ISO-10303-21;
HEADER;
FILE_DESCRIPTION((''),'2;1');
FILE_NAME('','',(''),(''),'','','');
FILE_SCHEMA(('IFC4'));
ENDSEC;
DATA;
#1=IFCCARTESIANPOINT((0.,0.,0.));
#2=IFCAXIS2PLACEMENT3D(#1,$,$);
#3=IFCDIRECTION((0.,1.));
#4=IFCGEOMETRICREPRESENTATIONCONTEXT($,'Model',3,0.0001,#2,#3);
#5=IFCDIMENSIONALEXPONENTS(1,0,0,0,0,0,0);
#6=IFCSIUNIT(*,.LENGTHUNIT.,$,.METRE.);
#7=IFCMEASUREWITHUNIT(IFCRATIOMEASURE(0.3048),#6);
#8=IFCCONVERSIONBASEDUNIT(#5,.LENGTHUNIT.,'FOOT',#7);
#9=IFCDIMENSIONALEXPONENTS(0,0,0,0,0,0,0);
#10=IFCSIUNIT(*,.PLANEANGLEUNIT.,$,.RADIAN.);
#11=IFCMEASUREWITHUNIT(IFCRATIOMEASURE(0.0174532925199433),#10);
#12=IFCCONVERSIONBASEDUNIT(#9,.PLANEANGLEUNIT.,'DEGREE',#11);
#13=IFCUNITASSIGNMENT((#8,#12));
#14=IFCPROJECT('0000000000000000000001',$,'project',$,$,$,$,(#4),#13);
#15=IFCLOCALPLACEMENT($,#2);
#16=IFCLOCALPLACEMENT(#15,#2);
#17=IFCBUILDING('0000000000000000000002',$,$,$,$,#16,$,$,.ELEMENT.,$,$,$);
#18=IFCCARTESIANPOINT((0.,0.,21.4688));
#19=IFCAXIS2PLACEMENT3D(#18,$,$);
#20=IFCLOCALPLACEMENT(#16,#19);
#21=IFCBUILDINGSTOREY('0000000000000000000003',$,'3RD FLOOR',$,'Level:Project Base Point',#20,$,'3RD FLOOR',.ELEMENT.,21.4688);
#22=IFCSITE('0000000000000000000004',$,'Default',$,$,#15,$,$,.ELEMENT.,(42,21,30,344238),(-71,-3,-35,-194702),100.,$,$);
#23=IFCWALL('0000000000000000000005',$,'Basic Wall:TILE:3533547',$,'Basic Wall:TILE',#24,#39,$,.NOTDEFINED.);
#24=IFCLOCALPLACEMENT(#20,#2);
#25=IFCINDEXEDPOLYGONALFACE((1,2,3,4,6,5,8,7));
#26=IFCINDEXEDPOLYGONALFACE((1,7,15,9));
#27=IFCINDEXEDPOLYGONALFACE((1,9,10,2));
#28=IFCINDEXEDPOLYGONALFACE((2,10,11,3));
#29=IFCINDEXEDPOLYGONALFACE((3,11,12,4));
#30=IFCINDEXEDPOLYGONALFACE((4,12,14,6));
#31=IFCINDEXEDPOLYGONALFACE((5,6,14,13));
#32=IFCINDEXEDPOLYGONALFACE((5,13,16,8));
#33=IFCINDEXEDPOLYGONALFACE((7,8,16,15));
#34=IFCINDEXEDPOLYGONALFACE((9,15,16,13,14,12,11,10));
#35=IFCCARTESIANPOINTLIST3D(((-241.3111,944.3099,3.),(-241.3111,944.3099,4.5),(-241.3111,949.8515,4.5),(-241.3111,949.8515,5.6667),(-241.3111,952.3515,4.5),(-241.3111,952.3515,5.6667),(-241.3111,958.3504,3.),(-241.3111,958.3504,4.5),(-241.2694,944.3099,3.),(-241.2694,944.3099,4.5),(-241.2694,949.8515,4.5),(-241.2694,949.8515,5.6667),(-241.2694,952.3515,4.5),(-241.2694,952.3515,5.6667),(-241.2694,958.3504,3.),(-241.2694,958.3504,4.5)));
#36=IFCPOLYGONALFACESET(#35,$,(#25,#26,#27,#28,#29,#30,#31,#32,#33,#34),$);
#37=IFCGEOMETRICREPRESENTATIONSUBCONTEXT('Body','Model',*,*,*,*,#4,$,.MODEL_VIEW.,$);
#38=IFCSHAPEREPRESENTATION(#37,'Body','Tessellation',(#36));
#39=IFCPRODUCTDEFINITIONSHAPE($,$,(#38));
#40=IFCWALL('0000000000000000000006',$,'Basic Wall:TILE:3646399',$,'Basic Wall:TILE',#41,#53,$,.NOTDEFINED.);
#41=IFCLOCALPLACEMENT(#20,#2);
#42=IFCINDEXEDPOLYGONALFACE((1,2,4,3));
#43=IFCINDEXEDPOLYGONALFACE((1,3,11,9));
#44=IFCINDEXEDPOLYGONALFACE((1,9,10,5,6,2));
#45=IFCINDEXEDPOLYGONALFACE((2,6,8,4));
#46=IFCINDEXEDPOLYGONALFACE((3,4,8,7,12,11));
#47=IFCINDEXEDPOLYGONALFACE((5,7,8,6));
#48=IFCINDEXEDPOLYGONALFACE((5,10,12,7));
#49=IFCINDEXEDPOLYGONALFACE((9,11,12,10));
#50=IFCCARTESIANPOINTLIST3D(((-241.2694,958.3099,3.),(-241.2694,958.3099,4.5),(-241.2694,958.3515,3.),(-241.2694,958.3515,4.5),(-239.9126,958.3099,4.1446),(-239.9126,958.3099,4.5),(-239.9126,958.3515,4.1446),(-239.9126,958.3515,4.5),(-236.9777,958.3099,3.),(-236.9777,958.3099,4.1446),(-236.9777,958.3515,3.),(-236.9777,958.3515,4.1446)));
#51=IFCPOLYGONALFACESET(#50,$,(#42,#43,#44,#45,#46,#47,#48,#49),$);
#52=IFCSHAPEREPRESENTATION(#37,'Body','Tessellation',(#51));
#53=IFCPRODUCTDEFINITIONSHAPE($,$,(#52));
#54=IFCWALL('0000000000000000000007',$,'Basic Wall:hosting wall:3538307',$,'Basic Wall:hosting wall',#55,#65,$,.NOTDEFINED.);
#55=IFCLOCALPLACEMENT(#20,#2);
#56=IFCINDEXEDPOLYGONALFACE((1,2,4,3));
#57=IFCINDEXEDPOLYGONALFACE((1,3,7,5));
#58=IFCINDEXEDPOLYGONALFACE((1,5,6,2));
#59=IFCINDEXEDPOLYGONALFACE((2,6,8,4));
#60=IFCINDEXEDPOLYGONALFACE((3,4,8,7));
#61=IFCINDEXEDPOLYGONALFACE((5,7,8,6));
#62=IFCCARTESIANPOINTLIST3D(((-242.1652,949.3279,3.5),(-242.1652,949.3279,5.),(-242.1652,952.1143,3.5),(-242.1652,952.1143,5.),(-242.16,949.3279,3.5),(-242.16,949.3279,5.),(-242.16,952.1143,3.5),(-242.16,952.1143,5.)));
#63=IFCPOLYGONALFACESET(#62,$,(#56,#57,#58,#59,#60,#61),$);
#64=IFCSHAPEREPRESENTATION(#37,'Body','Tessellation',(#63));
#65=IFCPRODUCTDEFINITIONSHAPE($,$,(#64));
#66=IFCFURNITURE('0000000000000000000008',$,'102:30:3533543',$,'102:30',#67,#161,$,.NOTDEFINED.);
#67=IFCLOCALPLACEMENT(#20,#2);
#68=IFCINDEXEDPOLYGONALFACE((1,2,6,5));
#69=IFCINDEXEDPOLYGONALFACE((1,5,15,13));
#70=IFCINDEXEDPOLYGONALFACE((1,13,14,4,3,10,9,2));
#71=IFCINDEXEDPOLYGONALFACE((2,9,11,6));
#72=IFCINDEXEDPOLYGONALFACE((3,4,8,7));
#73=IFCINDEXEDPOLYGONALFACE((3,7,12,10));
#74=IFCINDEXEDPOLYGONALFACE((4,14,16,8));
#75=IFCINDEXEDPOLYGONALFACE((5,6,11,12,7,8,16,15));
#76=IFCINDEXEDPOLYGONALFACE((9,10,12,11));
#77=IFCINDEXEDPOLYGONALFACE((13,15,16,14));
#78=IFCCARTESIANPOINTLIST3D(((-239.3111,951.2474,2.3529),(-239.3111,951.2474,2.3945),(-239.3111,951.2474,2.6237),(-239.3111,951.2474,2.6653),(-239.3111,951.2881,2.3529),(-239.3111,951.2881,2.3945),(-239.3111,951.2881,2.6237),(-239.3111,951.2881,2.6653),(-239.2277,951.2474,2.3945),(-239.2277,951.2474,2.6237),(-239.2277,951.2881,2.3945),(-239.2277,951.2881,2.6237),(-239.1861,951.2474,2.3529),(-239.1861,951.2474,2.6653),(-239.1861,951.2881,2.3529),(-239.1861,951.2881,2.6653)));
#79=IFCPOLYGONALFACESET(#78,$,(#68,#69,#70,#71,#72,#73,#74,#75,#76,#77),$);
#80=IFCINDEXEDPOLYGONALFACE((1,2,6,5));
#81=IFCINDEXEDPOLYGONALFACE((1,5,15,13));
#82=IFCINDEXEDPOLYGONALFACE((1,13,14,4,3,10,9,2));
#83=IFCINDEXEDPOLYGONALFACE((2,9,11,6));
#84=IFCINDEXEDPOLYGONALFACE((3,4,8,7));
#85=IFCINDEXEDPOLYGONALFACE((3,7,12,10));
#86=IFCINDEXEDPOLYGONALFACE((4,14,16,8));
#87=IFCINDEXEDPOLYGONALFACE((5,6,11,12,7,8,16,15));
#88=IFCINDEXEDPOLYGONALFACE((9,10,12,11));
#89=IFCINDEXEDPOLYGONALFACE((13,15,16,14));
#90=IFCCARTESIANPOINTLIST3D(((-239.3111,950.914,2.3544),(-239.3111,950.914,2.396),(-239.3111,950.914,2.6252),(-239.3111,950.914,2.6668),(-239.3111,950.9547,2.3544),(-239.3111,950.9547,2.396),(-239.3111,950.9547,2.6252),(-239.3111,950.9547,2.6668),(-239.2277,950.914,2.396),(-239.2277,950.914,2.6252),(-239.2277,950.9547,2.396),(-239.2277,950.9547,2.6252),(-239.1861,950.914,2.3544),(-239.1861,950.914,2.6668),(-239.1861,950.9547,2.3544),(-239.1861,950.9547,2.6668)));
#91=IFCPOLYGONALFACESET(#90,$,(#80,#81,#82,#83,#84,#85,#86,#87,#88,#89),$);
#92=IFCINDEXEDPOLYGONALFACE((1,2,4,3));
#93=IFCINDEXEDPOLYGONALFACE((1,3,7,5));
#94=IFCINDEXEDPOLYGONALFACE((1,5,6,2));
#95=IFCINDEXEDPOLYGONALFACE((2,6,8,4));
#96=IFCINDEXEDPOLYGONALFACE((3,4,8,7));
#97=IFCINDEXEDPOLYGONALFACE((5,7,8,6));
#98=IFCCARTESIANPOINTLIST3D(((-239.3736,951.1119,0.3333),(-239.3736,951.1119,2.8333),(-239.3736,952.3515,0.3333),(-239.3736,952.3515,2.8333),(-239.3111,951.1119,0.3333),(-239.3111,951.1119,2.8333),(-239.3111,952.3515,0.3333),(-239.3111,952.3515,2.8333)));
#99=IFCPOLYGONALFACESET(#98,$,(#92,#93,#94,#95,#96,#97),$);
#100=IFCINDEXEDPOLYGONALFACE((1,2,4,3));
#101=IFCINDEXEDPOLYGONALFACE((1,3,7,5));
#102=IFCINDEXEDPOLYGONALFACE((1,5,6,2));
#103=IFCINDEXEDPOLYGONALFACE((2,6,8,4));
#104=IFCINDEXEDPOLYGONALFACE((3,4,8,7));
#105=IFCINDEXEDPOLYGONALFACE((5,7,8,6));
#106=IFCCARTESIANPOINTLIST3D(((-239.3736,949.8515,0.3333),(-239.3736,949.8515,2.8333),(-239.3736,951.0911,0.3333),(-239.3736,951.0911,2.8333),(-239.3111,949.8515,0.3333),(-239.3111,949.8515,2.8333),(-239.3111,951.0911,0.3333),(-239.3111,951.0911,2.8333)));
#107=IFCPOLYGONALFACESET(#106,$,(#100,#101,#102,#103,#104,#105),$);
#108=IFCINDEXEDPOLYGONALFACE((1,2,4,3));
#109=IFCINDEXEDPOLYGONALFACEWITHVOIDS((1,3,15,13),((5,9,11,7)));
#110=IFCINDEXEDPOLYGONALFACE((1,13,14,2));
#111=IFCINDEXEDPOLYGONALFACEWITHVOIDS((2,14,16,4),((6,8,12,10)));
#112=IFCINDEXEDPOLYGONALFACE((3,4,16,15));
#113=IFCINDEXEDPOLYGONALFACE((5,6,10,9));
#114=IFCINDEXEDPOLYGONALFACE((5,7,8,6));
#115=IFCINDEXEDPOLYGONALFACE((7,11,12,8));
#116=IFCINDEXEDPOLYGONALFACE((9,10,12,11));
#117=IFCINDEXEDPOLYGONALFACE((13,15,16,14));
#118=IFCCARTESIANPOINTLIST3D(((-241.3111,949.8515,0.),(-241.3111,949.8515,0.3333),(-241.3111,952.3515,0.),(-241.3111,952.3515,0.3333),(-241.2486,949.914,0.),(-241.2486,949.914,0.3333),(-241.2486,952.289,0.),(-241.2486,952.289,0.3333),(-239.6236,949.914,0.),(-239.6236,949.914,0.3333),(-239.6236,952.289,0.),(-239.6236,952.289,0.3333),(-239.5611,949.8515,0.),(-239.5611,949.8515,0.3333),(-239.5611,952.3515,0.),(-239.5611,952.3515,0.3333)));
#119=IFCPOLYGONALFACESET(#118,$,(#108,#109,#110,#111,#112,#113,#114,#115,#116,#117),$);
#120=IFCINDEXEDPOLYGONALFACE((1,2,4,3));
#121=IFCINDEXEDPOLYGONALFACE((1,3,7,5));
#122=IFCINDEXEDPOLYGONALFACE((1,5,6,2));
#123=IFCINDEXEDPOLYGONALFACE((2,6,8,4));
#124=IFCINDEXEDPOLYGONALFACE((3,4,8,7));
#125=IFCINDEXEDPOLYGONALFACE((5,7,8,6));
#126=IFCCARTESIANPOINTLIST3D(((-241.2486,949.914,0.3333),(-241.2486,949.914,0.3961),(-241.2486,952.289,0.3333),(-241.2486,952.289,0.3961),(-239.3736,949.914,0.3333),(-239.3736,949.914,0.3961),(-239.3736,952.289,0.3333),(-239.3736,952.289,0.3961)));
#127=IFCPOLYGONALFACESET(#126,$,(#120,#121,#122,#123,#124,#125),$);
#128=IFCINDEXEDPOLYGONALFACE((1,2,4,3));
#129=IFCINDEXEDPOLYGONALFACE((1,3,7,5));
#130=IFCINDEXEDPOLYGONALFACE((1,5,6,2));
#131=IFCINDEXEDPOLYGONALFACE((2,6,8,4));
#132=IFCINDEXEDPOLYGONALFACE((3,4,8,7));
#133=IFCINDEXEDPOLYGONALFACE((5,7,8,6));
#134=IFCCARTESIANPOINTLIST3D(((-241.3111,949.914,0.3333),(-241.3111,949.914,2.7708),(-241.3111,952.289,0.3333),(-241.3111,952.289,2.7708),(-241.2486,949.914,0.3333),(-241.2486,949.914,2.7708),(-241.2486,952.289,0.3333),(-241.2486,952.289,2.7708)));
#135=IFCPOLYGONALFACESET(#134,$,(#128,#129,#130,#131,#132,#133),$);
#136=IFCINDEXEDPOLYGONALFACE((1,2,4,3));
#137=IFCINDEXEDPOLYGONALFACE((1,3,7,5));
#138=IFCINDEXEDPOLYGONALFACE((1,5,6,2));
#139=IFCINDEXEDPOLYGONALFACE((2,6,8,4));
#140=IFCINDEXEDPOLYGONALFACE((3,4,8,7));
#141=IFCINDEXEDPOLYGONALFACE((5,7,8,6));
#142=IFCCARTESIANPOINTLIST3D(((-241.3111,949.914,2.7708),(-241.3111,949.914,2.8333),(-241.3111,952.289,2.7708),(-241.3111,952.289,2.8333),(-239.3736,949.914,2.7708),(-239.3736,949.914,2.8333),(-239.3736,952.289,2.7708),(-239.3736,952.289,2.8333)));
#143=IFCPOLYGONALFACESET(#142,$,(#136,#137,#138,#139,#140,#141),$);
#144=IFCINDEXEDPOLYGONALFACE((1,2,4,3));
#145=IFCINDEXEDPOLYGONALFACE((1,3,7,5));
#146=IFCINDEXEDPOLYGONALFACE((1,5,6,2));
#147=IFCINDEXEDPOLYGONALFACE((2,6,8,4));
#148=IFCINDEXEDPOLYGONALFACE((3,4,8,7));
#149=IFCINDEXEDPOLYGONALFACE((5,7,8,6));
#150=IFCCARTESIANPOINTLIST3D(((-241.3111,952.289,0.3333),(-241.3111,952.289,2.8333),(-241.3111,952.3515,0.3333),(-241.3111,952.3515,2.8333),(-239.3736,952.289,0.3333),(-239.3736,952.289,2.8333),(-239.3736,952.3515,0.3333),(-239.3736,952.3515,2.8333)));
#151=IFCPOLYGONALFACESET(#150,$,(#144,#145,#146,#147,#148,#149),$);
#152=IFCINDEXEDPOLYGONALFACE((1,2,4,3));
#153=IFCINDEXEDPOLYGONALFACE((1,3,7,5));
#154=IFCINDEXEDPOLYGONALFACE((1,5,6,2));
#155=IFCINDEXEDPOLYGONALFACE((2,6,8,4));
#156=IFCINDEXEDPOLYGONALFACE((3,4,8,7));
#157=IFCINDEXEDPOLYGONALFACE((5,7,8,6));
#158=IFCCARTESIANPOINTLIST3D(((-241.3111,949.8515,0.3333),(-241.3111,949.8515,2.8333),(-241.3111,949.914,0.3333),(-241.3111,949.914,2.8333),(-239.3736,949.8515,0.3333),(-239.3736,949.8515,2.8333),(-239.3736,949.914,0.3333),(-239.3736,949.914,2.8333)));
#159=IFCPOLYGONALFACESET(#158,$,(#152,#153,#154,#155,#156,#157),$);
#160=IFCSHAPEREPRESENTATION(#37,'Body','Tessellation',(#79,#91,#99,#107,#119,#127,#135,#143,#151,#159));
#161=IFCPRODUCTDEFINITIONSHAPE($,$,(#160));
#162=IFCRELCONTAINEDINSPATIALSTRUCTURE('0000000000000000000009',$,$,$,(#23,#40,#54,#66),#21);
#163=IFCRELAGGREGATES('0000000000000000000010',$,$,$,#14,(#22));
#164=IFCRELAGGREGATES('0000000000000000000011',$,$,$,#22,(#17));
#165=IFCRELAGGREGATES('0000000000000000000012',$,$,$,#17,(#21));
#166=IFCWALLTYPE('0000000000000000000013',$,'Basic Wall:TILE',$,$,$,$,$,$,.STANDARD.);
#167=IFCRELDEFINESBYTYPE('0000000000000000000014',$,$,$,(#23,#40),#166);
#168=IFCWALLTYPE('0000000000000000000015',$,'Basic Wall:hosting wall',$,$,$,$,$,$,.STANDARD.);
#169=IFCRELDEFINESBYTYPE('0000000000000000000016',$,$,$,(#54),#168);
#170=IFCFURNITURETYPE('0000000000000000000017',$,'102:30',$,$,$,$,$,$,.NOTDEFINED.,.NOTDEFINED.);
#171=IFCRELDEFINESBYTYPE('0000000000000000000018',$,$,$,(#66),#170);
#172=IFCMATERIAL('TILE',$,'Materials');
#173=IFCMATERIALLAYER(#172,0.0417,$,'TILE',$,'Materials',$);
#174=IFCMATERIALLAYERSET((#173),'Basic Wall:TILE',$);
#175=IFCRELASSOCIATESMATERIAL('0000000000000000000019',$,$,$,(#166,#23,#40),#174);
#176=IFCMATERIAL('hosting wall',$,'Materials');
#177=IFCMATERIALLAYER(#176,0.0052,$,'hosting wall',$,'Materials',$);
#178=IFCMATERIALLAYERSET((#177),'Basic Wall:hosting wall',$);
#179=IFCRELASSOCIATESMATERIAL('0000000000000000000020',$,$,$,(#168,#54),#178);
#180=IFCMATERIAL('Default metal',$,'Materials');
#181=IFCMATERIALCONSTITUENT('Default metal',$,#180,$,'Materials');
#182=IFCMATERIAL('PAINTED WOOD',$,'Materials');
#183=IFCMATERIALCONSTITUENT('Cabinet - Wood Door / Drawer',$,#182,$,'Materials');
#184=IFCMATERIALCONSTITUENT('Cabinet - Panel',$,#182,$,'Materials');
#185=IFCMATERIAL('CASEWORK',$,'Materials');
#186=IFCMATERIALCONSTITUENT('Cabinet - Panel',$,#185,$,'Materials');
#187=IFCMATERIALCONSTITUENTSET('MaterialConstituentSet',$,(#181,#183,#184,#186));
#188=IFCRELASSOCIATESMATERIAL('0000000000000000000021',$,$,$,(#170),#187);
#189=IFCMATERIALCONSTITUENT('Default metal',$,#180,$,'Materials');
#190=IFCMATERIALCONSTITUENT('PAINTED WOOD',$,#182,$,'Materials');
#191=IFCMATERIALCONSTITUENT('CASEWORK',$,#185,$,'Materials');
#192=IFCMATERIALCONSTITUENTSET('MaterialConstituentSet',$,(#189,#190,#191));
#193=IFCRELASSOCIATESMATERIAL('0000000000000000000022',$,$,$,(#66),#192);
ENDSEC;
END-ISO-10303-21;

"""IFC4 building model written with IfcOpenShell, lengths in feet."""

from ifc_helpers import new_model, entity, si_unit, converted_unit, direction, frame, frame_2d, origin, origin_2d_with_axis, place, context, subcontext, project, spatial, polyline, rectangle, outline, extrude, source, transform, mapped, material, layer, layer_set, layer_usage, constituent, constituent_set, type_object, type_shapes, element, save


model = new_model("IFC4")

# Units and contexts
model_context = context("Model", 3, precision=0.0001, world=origin(), true_north=direction((0.0, 1.0)))
body_context = subcontext(model_context, "Body", "Model", "MODEL_VIEW")
ifc_project = project(units=[converted_unit("LENGTHUNIT", "FOOT", entity("IfcRatioMeasure", 0.3048), si_unit("LENGTHUNIT", "METRE"), dimensions=[1, 0, 0, 0, 0, 0, 0]), converted_unit("PLANEANGLEUNIT", "DEGREE", entity("IfcRatioMeasure", 0.0174532925199433), si_unit("PLANEANGLEUNIT", "RADIAN"), dimensions=[0, 0, 0, 0, 0, 0, 0])], contexts=[model_context])

# Site, building, storey
site_placement = place(None, origin())
site = spatial("IfcSite", under=ifc_project, at=site_placement, Name="Default", CompositionType="ELEMENT", RefLatitude=(42, 21, 30, 344238), RefLongitude=(-71, -3, -35, -194702), RefElevation=100.0)
building_placement = place(site_placement, origin())
building = spatial("IfcBuilding", under=site, at=building_placement, CompositionType="ELEMENT")
storey_placement = place(building_placement, frame((0.0, 0.0, 21.4688)))
storey = spatial("IfcBuildingStorey", under=building, at=storey_placement, Name="3RD FLOOR", ObjectType="Level:Project Base Point", LongName="3RD FLOOR", CompositionType="ELEMENT", Elevation=21.4688)

# Wall, openings
ifc_material_1 = material(Name="TILE", Category="Materials")
ifc_layer_1 = layer(ifc_material_1, 0.0417, Name="TILE", Category="Materials")
ifc_layer_set_1 = layer_set([ifc_layer_1], Name="Basic Wall:TILE")
ifc_layer_usage_1 = layer_usage(ifc_layer_set_1, "AXIS2", "POSITIVE", -0.0208)
wall_type_1 = type_object("IfcWallType", Name="Basic Wall:TILE", PredefinedType="STANDARD", material=ifc_layer_set_1)
wall_1_placement = place(storey_placement, frame((-241.2902, 958.3504, 3.0), z_axis=(0.0, 0.0, 1.0), x_axis=(0.0, -1.0, 0.0)))
wall_1 = element("IfcWall", 1, at=wall_1_placement, inside=storey, type_object=wall_type_1, material=ifc_layer_usage_1, Name="Basic Wall:TILE:3533547", ObjectType="Basic Wall:TILE", PredefinedType="NOTDEFINED", context=body_context, shape_type="SweptSolid", body=[
    extrude(rectangle(XDim=14.0406, YDim=0.0417, at=frame_2d((7.0203, 0.0), x_axis=(-1.0, 0.0))), origin(), (0.0, 0.0, 1.0), 2.6667),
])
opening_1_placement = place(wall_1_placement, origin())
element("IfcOpeningElement", 2, at=opening_1_placement, cuts=wall_1, PredefinedType="OPENING", context=body_context, shape_type="SweptSolid", body=[
    extrude(rectangle(XDim=1.1667, YDim=5.5417, at=origin_2d_with_axis()), frame((11.2697, 0.0208, 2.0833), z_axis=(0.0, -1.0, 0.0), x_axis=(0.0, 0.0, 1.0)), (0.0, 0.0, 1.0), 0.0417),
])
opening_2_placement = place(wall_1_placement, origin())
element("IfcOpeningElement", 3, at=opening_2_placement, cuts=wall_1, PredefinedType="OPENING", context=body_context, shape_type="SweptSolid", body=[
    extrude(rectangle(XDim=1.1667, YDim=5.9989, at=frame_2d((0.0, 0.0), x_axis=(0.0, 1.0))), frame((2.9994, 0.0208, 2.0833), z_axis=(0.0, -1.0, 0.0), x_axis=(-1.0, 0.0, 0.0)), (0.0, 0.0, 1.0), 0.0417),
])

# Wall, opening
ifc_layer_usage_2 = layer_usage(ifc_layer_set_1, "AXIS2", "NEGATIVE", 0.0208)
wall_2_placement = place(storey_placement, frame((-241.2694, 958.3307, 3.0)))
wall_2 = element("IfcWall", 4, at=wall_2_placement, inside=storey, type_object=wall_type_1, material=ifc_layer_usage_2, Name="Basic Wall:TILE:3646399", ObjectType="Basic Wall:TILE", PredefinedType="NOTDEFINED", context=body_context, shape_type="SweptSolid", body=[
    extrude(rectangle(XDim=4.2917, YDim=0.0417, at=frame_2d((2.1458, 0.0), x_axis=(-1.0, 0.0))), origin(), (0.0, 0.0, 1.0), 1.5),
])
opening_3_placement = place(wall_2_placement, origin())
element("IfcOpeningElement", 5, at=opening_3_placement, cuts=wall_2, PredefinedType="OPENING", context=body_context, shape_type="SweptSolid", body=[
    extrude(rectangle(XDim=0.3554, YDim=2.9349, at=frame_2d((0.0, 0.0), x_axis=(1.0, 0.0))), frame((2.8242, 0.0208, 1.3223), z_axis=(0.0, -1.0, 0.0), x_axis=(0.0, 0.0, 1.0)), (0.0, 0.0, 1.0), 0.0417),
])

# Wall
ifc_material_2 = material(Name="hosting wall", Category="Materials")
ifc_layer_2 = layer(ifc_material_2, 0.0052, Name="hosting wall", Category="Materials")
ifc_layer_set_2 = layer_set([ifc_layer_2], Name="Basic Wall:hosting wall")
ifc_layer_usage_3 = layer_usage(ifc_layer_set_2, "AXIS2", "POSITIVE", -0.0026)
wall_type_2 = type_object("IfcWallType", Name="Basic Wall:hosting wall", PredefinedType="STANDARD", material=ifc_layer_set_2)
wall_3_placement = place(storey_placement, frame((-242.1626, 949.3279, 3.5), z_axis=(0.0, 0.0, 1.0), x_axis=(0.0, 1.0, 0.0)))
element("IfcWall", 6, at=wall_3_placement, inside=storey, type_object=wall_type_2, material=ifc_layer_usage_3, Name="Basic Wall:hosting wall:3538307", ObjectType="Basic Wall:hosting wall", PredefinedType="NOTDEFINED", context=body_context, shape_type="SweptSolid", body=[
    extrude(rectangle(XDim=2.7865, YDim=0.0052, at=frame_2d((1.3932, 0.0), x_axis=(-1.0, 0.0))), origin(), (0.0, 0.0, 1.0), 1.5),
])

# Furniture
ifc_material_3 = material(Name="Default metal", Category="Materials")
ifc_material_4 = material(Name="PAINTED WOOD", Category="Materials")
ifc_material_5 = material(Name="CASEWORK", Category="Materials")
ifc_constituent_1 = constituent(ifc_material_3, Name="Default metal", Category="Materials")
ifc_constituent_2 = constituent(ifc_material_4, Name="PAINTED WOOD", Category="Materials")
ifc_constituent_3 = constituent(ifc_material_5, Name="CASEWORK", Category="Materials")
ifc_constituent_set_1 = constituent_set(constituents=[ifc_constituent_1, ifc_constituent_2, ifc_constituent_3], Name="MaterialConstituentSet")
ifc_constituent_4 = constituent(ifc_material_3, Name="Default metal", Category="Materials")
ifc_constituent_5 = constituent(ifc_material_4, Name="Cabinet - Wood Door / Drawer", Category="Materials")
ifc_constituent_6 = constituent(ifc_material_4, Name="Cabinet - Panel", Category="Materials")
ifc_constituent_7 = constituent(ifc_material_5, Name="Cabinet - Panel", Category="Materials")
ifc_constituent_set_2 = constituent_set(constituents=[ifc_constituent_4, ifc_constituent_5, ifc_constituent_6, ifc_constituent_7], Name="MaterialConstituentSet")
furniture_type_1 = type_object("IfcFurnitureType", Name="102:30", AssemblyPlace="NOTDEFINED", PredefinedType="NOTDEFINED", material=ifc_constituent_set_2)
shared_shape_1 = source(origin(), body_context, "Body", "SweptSolid", [
    extrude(outline(polyline([(0.1146, -0.0521), (0.1562, -0.0521), (0.1562, 0.0729), (-0.1562, 0.0729), (-0.1562, -0.0521), (-0.1146, -0.0521), (-0.1146, 0.0313), (0.1146, 0.0313), (0.1146, -0.0521)])), frame((0.2073, -2.0521, 2.5091), z_axis=(1.0, 0.0, 0.0), x_axis=(0.0, 0.0, 1.0)), (0.0, 0.0, 1.0), 0.0407),
    extrude(outline(polyline([(0.1146, -0.0521), (0.1562, -0.0521), (0.1562, 0.0729), (-0.1562, 0.0729), (-0.1562, -0.0521), (-0.1146, -0.0521), (-0.1146, 0.0313), (0.1146, 0.0313), (0.1146, -0.0521)])), frame((-0.126, -2.0521, 2.5106), z_axis=(1.0, 0.0, 0.0), x_axis=(0.0, 0.0, 1.0)), (0.0, 0.0, 1.0), 0.0407),
    extrude(rectangle(XDim=0.0625, YDim=1.2396, at=frame_2d((0.0, 0.0), x_axis=(1.0, 0.0))), frame((0.6917, -1.9688, 0.3333), z_axis=(0.0, 0.0, 1.0), x_axis=(0.0, 1.0, 0.0)), (0.0, 0.0, 1.0), 2.5),
    extrude(rectangle(XDim=0.0625, YDim=1.2396, at=origin_2d_with_axis()), frame((-0.5687, -1.9688, 0.3333), z_axis=(0.0, 0.0, 1.0), x_axis=(0.0, 1.0, 0.0)), (0.0, 0.0, 1.0), 2.5),
    extrude(outline(polyline([(-1.25, -0.875), (1.25, -0.875), (1.25, 0.875), (-1.25, 0.875), (-1.25, -0.875)]), holes=[polyline([(-1.1875, -0.8125), (-1.1875, 0.8125), (1.1875, 0.8125), (1.1875, -0.8125), (-1.1875, -0.8125)])]), frame((0.0615, -0.875, 0.0)), (0.0, 0.0, 1.0), 0.3333),
    extrude(rectangle(XDim=2.375, YDim=1.875, at=frame_2d((0.0, 0.0), x_axis=(1.0, 0.0))), frame((0.0615, -1.0, 0.3333), z_axis=(0.0, 0.0, 1.0), x_axis=(-1.0, 0.0, 0.0)), (0.0, 0.0, 1.0), 0.0627),
    extrude(rectangle(XDim=0.0625, YDim=2.375, at=origin_2d_with_axis()), frame((0.0615, -0.0312, 0.3333), z_axis=(0.0, 0.0, 1.0), x_axis=(0.0, 1.0, 0.0)), (0.0, 0.0, 1.0), 2.4375),
    extrude(rectangle(XDim=2.375, YDim=1.9375, at=origin_2d_with_axis()), frame((0.0615, -0.9688, 2.7708), z_axis=(0.0, 0.0, 1.0), x_axis=(-1.0, 0.0, 0.0)), (0.0, 0.0, 1.0), 0.0625),
    extrude(rectangle(XDim=0.0625, YDim=1.9375, at=frame_2d((0.0, 0.0), x_axis=(1.0, 0.0))), frame((1.2802, -0.9687, 0.3333)), (0.0, 0.0, 1.0), 2.5),
    extrude(rectangle(XDim=0.0625, YDim=1.9375, at=frame_2d((0.0, 0.0), x_axis=(1.0, 0.0))), frame((-1.1573, -0.9687, 0.3333)), (0.0, 0.0, 1.0), 2.5),
])
type_shapes(furniture_type_1, [shared_shape_1])
furniture_1_placement = place(storey_placement, frame((-241.3111, 951.04, 0.0), z_axis=(0.0, 0.0, 1.0), x_axis=(0.0, 1.0, 0.0)))
element("IfcFurniture", 7, at=furniture_1_placement, inside=storey, type_object=furniture_type_1, material=ifc_constituent_set_1, Name="102:30:3533543", ObjectType="102:30", PredefinedType="NOTDEFINED", context=body_context, shape_type="MappedRepresentation", body=[
    mapped(shared_shape_1, transform((0.0, 0.0, 0.0), scale=1.0)),
])

save(model, "model.ifc")
